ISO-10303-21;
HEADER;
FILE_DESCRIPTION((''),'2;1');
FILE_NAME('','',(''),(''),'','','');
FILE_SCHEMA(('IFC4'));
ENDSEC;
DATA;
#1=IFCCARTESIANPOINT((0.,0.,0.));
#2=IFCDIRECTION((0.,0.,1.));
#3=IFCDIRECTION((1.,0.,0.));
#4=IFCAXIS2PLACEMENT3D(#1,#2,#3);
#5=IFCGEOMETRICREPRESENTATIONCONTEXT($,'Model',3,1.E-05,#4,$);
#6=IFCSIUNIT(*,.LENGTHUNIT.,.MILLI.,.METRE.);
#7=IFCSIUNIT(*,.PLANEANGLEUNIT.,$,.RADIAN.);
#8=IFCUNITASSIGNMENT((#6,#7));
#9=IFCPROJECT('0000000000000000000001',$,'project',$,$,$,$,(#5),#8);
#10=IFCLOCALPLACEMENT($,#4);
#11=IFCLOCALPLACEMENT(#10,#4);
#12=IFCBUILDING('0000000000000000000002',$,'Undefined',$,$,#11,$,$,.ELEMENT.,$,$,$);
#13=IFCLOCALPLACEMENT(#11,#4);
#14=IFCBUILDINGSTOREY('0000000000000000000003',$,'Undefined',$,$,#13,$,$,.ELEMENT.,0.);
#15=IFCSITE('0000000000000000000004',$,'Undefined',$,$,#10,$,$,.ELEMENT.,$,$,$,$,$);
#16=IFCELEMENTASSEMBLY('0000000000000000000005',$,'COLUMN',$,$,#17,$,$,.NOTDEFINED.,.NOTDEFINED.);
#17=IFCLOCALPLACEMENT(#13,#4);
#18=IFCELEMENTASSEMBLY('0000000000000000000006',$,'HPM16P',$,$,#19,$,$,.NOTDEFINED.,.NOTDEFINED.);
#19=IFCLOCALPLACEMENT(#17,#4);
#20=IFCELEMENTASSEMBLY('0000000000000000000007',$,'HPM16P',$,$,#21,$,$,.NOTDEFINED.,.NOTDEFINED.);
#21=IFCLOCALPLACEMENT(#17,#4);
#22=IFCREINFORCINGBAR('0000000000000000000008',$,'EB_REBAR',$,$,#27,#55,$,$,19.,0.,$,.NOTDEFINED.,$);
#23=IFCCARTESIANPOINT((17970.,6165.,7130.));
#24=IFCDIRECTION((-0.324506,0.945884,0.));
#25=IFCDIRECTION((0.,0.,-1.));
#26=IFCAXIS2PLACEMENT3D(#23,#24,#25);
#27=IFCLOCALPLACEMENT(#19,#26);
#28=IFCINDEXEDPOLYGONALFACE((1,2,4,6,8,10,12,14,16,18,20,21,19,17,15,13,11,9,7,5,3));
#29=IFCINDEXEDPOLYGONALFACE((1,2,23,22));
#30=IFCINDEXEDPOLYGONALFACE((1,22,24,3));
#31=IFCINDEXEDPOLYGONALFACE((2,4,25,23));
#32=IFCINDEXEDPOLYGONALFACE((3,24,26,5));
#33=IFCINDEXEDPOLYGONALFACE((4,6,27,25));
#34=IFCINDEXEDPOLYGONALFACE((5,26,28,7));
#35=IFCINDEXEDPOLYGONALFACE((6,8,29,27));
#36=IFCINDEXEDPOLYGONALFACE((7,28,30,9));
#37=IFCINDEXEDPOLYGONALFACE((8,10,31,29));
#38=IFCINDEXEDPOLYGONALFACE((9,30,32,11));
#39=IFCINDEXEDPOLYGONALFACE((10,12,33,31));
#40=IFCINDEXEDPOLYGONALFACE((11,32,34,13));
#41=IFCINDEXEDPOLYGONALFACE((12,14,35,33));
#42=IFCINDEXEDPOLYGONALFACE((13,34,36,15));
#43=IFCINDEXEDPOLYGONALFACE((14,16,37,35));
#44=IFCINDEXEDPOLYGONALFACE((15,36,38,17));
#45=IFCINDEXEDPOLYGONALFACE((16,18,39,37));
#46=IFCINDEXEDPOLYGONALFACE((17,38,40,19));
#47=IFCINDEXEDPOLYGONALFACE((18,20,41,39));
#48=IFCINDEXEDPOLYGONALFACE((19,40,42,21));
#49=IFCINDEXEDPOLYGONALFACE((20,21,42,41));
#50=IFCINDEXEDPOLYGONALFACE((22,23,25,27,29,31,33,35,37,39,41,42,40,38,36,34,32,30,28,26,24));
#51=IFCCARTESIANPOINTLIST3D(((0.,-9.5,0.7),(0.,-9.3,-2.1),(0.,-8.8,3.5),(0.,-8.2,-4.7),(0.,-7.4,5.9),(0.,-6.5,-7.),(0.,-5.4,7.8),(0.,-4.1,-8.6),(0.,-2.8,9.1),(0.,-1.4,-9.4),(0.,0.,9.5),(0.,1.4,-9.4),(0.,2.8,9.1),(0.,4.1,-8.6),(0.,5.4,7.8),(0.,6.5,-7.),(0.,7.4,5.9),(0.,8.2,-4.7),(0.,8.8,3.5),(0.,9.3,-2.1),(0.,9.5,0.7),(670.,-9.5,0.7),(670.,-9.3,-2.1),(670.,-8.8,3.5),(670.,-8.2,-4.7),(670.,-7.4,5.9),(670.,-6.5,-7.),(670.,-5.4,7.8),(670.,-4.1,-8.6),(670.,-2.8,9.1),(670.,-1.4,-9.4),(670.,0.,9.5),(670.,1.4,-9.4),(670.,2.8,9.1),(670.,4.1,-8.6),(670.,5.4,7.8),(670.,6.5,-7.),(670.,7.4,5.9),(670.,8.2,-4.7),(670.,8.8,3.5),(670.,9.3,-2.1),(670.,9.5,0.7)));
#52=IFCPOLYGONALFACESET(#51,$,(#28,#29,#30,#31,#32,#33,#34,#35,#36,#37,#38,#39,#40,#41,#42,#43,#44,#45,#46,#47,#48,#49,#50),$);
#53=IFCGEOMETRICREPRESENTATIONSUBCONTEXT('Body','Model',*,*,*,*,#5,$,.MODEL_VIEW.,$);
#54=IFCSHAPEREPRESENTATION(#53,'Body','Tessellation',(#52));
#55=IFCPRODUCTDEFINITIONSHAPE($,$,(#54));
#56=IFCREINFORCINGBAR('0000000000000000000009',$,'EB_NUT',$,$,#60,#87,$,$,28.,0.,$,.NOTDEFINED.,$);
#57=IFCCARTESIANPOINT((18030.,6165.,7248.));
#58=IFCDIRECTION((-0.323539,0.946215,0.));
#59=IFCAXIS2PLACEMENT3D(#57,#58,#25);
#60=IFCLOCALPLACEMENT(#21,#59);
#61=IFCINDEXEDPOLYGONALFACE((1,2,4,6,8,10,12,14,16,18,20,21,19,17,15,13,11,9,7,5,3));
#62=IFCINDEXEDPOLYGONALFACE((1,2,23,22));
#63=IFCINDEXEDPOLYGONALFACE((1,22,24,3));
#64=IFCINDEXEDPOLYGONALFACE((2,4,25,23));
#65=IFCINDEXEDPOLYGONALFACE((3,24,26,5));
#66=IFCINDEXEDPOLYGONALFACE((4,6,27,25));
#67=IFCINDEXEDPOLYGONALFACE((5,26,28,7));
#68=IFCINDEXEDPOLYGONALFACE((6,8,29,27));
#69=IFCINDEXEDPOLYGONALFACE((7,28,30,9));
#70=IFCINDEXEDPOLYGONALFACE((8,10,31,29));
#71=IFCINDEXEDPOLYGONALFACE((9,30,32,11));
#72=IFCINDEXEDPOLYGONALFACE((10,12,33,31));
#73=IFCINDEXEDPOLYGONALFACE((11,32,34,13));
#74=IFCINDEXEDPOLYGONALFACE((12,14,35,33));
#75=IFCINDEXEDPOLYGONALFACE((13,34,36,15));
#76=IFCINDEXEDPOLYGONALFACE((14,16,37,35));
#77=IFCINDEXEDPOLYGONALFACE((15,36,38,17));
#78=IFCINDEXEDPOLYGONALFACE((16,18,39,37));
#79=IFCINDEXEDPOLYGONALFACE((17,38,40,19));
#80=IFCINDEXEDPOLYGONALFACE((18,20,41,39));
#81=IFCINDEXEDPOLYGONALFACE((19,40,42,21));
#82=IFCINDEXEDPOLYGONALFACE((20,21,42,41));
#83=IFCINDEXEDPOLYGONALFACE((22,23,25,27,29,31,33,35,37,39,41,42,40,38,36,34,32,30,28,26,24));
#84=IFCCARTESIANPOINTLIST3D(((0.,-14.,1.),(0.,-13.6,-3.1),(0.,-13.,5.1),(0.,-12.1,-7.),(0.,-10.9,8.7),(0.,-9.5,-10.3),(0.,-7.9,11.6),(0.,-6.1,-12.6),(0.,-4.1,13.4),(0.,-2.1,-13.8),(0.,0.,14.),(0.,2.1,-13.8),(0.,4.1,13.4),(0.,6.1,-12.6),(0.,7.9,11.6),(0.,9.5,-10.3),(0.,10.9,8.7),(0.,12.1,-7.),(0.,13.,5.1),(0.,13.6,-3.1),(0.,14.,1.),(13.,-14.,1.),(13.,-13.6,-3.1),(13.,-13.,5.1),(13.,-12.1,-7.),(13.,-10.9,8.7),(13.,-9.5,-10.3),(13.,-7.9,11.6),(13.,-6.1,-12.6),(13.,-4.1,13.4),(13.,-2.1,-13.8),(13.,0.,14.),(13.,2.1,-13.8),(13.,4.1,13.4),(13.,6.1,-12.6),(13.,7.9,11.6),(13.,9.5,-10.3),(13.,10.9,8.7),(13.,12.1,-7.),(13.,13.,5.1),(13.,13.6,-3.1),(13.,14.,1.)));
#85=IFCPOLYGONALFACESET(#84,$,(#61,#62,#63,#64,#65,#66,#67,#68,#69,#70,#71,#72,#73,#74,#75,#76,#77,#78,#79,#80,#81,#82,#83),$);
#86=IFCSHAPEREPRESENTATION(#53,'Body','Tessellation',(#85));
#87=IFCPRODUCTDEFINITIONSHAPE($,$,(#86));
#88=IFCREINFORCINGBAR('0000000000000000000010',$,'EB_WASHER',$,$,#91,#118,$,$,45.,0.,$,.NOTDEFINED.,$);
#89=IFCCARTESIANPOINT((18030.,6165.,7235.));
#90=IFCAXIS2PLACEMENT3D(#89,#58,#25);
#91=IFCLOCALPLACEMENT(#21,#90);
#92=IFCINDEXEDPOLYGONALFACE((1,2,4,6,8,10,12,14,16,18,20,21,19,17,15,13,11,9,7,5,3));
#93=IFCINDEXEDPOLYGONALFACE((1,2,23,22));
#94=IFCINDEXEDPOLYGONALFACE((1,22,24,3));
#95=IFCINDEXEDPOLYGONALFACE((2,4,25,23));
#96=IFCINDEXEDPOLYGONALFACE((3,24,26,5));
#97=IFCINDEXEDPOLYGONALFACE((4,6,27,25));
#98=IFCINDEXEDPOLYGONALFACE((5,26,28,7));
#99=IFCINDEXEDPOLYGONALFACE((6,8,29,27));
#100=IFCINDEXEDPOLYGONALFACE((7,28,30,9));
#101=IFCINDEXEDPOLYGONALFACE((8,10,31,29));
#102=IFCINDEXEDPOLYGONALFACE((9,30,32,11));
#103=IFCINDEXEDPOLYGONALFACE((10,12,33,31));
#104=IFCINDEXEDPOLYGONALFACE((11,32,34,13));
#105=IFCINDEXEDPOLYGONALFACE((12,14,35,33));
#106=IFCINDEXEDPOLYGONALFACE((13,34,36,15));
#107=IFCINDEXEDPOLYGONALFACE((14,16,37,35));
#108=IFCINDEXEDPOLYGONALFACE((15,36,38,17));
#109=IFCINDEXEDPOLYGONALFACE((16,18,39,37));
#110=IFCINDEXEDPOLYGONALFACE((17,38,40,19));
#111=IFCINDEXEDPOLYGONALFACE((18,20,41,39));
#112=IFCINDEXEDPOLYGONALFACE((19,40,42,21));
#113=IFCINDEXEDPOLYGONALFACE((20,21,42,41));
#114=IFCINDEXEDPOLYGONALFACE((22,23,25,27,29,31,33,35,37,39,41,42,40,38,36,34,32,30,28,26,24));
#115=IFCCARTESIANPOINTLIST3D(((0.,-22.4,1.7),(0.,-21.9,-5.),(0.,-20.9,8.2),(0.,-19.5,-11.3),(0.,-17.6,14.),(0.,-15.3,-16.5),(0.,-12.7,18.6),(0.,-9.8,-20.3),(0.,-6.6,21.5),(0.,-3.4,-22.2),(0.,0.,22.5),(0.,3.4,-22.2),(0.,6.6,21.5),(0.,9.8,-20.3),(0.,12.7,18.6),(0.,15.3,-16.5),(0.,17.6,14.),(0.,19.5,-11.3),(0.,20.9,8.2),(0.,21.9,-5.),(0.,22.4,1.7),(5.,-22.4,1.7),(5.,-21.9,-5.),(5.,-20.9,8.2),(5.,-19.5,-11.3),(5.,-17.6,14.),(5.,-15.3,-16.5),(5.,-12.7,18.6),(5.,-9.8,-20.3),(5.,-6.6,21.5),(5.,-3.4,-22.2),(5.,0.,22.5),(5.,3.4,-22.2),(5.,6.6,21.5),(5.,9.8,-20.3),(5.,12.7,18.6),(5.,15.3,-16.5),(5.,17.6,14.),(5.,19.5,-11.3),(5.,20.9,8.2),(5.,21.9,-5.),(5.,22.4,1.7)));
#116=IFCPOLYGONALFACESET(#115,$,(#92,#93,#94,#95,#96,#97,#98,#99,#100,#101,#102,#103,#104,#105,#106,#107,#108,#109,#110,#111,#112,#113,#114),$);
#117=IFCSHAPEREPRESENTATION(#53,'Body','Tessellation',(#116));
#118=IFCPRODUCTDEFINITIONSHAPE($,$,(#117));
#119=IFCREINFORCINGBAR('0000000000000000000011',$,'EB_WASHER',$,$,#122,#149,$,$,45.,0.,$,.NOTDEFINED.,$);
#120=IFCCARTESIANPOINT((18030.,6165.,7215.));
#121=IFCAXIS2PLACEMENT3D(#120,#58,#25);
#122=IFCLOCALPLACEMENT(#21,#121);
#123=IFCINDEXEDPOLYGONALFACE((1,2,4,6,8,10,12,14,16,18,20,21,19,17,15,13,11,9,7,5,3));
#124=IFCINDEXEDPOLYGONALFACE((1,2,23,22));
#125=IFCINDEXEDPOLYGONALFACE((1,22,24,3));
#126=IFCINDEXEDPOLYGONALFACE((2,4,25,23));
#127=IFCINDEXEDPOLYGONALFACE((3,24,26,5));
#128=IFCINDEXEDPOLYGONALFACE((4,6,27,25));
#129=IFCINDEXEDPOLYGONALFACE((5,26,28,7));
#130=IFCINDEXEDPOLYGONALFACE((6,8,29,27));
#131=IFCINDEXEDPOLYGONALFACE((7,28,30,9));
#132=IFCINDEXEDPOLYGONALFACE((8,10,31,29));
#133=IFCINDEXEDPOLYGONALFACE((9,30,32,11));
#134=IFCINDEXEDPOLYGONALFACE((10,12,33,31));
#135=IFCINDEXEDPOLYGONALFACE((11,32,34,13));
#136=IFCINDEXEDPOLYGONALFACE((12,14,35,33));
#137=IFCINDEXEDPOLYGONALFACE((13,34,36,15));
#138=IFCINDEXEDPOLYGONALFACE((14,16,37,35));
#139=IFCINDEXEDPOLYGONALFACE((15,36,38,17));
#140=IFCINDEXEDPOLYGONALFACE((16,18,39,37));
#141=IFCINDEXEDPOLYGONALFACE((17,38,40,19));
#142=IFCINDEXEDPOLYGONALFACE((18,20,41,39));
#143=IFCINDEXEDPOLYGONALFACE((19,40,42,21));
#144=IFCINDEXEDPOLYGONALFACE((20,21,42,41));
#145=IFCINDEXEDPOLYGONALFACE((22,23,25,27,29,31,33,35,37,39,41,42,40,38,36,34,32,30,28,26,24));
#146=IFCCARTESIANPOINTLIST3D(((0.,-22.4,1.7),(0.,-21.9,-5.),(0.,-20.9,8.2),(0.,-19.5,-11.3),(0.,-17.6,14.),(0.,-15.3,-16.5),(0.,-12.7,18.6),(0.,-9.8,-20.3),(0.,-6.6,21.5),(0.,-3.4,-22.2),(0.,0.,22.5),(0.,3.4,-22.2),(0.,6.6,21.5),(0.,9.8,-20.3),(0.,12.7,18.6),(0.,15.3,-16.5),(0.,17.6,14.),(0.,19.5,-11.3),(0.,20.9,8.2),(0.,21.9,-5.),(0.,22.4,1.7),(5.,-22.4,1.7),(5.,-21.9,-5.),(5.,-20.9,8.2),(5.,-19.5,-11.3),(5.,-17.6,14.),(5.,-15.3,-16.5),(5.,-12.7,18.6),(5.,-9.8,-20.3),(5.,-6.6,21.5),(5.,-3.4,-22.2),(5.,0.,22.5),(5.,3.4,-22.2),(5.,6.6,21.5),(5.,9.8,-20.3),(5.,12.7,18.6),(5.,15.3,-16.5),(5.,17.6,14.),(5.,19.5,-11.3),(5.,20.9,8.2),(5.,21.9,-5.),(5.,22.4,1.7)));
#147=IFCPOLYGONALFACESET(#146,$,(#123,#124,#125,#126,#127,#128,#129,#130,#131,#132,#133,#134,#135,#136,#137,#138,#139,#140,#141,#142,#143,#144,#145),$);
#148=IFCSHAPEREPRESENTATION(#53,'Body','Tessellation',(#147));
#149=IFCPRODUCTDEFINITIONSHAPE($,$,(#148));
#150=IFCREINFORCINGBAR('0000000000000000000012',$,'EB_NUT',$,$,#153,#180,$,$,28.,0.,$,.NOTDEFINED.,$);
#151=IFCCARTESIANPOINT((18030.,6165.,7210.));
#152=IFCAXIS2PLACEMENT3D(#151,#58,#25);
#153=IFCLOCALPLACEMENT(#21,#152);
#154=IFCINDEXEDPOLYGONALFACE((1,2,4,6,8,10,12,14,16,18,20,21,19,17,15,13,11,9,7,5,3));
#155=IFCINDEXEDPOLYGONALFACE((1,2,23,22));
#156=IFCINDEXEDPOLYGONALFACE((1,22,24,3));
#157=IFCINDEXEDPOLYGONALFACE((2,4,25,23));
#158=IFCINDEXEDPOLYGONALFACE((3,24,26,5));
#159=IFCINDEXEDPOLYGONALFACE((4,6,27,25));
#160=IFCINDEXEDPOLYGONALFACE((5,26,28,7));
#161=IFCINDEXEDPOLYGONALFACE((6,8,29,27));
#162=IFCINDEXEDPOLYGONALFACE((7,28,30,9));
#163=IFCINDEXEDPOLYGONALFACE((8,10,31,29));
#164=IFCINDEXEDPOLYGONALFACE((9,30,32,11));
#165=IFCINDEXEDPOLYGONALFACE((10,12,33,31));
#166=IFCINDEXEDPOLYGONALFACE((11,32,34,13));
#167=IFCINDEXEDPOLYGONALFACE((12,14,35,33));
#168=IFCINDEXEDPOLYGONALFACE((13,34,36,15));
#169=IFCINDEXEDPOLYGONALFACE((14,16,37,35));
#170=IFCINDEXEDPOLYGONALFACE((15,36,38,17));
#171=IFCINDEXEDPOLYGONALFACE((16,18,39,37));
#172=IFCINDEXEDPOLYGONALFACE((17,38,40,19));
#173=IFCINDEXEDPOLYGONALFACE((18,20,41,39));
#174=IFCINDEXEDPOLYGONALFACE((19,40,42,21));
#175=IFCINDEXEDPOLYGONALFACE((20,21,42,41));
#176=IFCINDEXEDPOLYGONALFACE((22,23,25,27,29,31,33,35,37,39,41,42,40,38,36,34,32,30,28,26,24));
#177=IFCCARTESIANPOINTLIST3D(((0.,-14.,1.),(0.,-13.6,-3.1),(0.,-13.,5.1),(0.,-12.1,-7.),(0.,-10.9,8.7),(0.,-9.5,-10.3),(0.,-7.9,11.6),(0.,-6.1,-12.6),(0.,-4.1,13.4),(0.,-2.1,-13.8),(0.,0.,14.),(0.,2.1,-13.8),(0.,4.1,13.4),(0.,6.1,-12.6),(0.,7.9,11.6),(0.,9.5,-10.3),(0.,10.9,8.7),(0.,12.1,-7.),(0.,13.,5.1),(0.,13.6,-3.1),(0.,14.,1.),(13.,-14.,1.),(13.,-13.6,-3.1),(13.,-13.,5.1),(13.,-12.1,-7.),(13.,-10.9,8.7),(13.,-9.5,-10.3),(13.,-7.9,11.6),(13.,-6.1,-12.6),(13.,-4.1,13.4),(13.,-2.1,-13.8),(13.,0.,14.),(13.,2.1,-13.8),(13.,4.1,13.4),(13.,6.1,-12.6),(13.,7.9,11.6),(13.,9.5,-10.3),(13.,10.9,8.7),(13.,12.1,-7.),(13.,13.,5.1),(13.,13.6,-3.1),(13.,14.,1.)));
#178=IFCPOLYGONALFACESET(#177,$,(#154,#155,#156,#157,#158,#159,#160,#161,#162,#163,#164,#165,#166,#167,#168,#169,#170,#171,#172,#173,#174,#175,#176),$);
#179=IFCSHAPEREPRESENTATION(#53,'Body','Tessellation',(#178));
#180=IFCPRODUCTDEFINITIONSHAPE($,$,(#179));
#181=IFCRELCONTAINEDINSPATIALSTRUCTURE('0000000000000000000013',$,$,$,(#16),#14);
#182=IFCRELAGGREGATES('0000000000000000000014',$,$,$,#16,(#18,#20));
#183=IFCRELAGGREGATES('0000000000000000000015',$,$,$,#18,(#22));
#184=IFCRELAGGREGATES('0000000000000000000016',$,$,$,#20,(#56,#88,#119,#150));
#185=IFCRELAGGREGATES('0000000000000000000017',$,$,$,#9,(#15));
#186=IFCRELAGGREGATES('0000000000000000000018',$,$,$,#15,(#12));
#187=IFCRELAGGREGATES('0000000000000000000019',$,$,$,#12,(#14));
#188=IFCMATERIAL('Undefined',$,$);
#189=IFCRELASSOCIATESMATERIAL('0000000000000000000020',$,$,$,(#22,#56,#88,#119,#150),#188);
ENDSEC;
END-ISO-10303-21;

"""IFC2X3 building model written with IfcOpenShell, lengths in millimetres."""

from ifc_helpers import new_model, entity, si_unit, frame, origin_with_axes, place, context, subcontext, project, spatial, source, transform, mapped, material, element, aggregate, save


model = new_model("IFC2X3")

# Units and contexts
model_context = context("Model", 3, precision=1e-05, world=origin_with_axes())
body_context = subcontext(model_context, "Body", "Model", "MODEL_VIEW")
ifc_project = project(units=[si_unit("LENGTHUNIT", "METRE", prefix="MILLI"), si_unit("PLANEANGLEUNIT", "RADIAN")], contexts=[model_context])

# Site, building, storey
site_placement = place(None, origin_with_axes())
site = spatial("IfcSite", under=ifc_project, at=site_placement, Name="Undefined", CompositionType="ELEMENT")
building_placement = place(site_placement, origin_with_axes())
building = spatial("IfcBuilding", under=site, at=building_placement, Name="Undefined", CompositionType="ELEMENT")
storey_placement = place(building_placement, origin_with_axes())
storey = spatial("IfcBuildingStorey", under=building, at=storey_placement, Name="Undefined", CompositionType="ELEMENT", Elevation=0.0)

# Element assemblies
assembly_1_placement = place(storey_placement, origin_with_axes())
assembly_1 = element("IfcElementAssembly", 1, at=assembly_1_placement, inside=storey, Name="COLUMN", AssemblyPlace="NOTDEFINED", PredefinedType="NOTDEFINED")
assembly_2_placement = place(assembly_1_placement, origin_with_axes())
assembly_2 = element("IfcElementAssembly", 2, at=assembly_2_placement, Name="HPM16P", AssemblyPlace="NOTDEFINED", PredefinedType="NOTDEFINED")
assembly_3_placement = place(assembly_1_placement, origin_with_axes())
assembly_3 = element("IfcElementAssembly", 3, at=assembly_3_placement, Name="HPM16P", AssemblyPlace="NOTDEFINED", PredefinedType="NOTDEFINED")

aggregate(assembly_1, [assembly_2, assembly_3])

# Shared definitions
ifc_material_1 = material(Name="Undefined")

# Reinforcing bars
shared_shape_1 = source(origin_with_axes(), body_context, "Body", "AdvancedSweptSolid", [
    entity("IfcSweptDiskSolid", entity("IfcTrimmedCurve", entity("IfcLine", entity("IfcCartesianPoint", [0.0, 0.0, 0.0]), entity("IfcVector", entity("IfcDirection", [1.0, 0.0, 0.0]), 1.0)), [entity("IfcParameterValue", 0.0)], [entity("IfcParameterValue", 670.0)], True, "PARAMETER"), 9.5, None, 0.0, 670.0),
])
reinforcing_bar_1_placement = place(assembly_2_placement, frame((17970.0, 6165.0, 7130.0), z_axis=(-0.324506, 0.945884, 0.0), x_axis=(0.0, 0.0, -1.0)))
reinforcing_bar_1 = element("IfcReinforcingBar", 4, at=reinforcing_bar_1_placement, material=ifc_material_1, Name="EB_REBAR", BarRole="NOTDEFINED", CrossSectionArea=0.0, NominalDiameter=19.0, context=body_context, shape_type="MappedRepresentation", body=[
    mapped(shared_shape_1, transform((0.0, 0.0, 0.0))),
])
aggregate(assembly_2, [reinforcing_bar_1])
shared_shape_2 = source(origin_with_axes(), body_context, "Body", "AdvancedSweptSolid", [
    entity("IfcSweptDiskSolid", entity("IfcTrimmedCurve", entity("IfcLine", entity("IfcCartesianPoint", [0.0, 0.0, 0.0]), entity("IfcVector", entity("IfcDirection", [1.0, 0.0, 0.0]), 1.0)), [entity("IfcParameterValue", 0.0)], [entity("IfcParameterValue", 13.0)], True, "PARAMETER"), 14.0, None, 0.0, 13.0),
])
reinforcing_bar_2_placement = place(assembly_3_placement, frame((18030.0, 6165.0, 7248.0), z_axis=(-0.323539, 0.946215, 0.0), x_axis=(0.0, 0.0, -1.0)))
reinforcing_bar_2 = element("IfcReinforcingBar", 5, at=reinforcing_bar_2_placement, material=ifc_material_1, Name="EB_NUT", BarRole="NOTDEFINED", CrossSectionArea=0.0, NominalDiameter=28.0, context=body_context, shape_type="MappedRepresentation", body=[
    mapped(shared_shape_2, transform((0.0, 0.0, 0.0))),
])
shared_shape_3 = source(origin_with_axes(), body_context, "Body", "AdvancedSweptSolid", [
    entity("IfcSweptDiskSolid", entity("IfcTrimmedCurve", entity("IfcLine", entity("IfcCartesianPoint", [0.0, 0.0, 0.0]), entity("IfcVector", entity("IfcDirection", [1.0, 0.0, 0.0]), 1.0)), [entity("IfcParameterValue", 0.0)], [entity("IfcParameterValue", 5.0)], True, "PARAMETER"), 22.5, None, 0.0, 5.0),
])
reinforcing_bar_3_placement = place(assembly_3_placement, frame((18030.0, 6165.0, 7235.0), z_axis=(-0.323539, 0.946215, 0.0), x_axis=(0.0, 0.0, -1.0)))
reinforcing_bar_3 = element("IfcReinforcingBar", 6, at=reinforcing_bar_3_placement, material=ifc_material_1, Name="EB_WASHER", BarRole="NOTDEFINED", CrossSectionArea=0.0, NominalDiameter=45.0, context=body_context, shape_type="MappedRepresentation", body=[
    mapped(shared_shape_3, transform((0.0, 0.0, 0.0))),
])
shared_shape_4 = source(origin_with_axes(), body_context, "Body", "AdvancedSweptSolid", [
    entity("IfcSweptDiskSolid", entity("IfcTrimmedCurve", entity("IfcLine", entity("IfcCartesianPoint", [0.0, 0.0, 0.0]), entity("IfcVector", entity("IfcDirection", [1.0, 0.0, 0.0]), 1.0)), [entity("IfcParameterValue", 0.0)], [entity("IfcParameterValue", 5.0)], True, "PARAMETER"), 22.5, None, 0.0, 5.0),
])
reinforcing_bar_4_placement = place(assembly_3_placement, frame((18030.0, 6165.0, 7215.0), z_axis=(-0.323539, 0.946215, 0.0), x_axis=(0.0, 0.0, -1.0)))
reinforcing_bar_4 = element("IfcReinforcingBar", 7, at=reinforcing_bar_4_placement, material=ifc_material_1, Name="EB_WASHER", BarRole="NOTDEFINED", CrossSectionArea=0.0, NominalDiameter=45.0, context=body_context, shape_type="MappedRepresentation", body=[
    mapped(shared_shape_4, transform((0.0, 0.0, 0.0))),
])
shared_shape_5 = source(origin_with_axes(), body_context, "Body", "AdvancedSweptSolid", [
    entity("IfcSweptDiskSolid", entity("IfcTrimmedCurve", entity("IfcLine", entity("IfcCartesianPoint", [0.0, 0.0, 0.0]), entity("IfcVector", entity("IfcDirection", [1.0, 0.0, 0.0]), 1.0)), [entity("IfcParameterValue", 0.0)], [entity("IfcParameterValue", 13.0)], True, "PARAMETER"), 14.0, None, 0.0, 13.0),
])
reinforcing_bar_5_placement = place(assembly_3_placement, frame((18030.0, 6165.0, 7210.0), z_axis=(-0.323539, 0.946215, 0.0), x_axis=(0.0, 0.0, -1.0)))
reinforcing_bar_5 = element("IfcReinforcingBar", 8, at=reinforcing_bar_5_placement, material=ifc_material_1, Name="EB_NUT", BarRole="NOTDEFINED", CrossSectionArea=0.0, NominalDiameter=28.0, context=body_context, shape_type="MappedRepresentation", body=[
    mapped(shared_shape_5, transform((0.0, 0.0, 0.0))),
])
aggregate(assembly_3, [reinforcing_bar_2, reinforcing_bar_3, reinforcing_bar_4, reinforcing_bar_5])

save(model, "model.ifc")
